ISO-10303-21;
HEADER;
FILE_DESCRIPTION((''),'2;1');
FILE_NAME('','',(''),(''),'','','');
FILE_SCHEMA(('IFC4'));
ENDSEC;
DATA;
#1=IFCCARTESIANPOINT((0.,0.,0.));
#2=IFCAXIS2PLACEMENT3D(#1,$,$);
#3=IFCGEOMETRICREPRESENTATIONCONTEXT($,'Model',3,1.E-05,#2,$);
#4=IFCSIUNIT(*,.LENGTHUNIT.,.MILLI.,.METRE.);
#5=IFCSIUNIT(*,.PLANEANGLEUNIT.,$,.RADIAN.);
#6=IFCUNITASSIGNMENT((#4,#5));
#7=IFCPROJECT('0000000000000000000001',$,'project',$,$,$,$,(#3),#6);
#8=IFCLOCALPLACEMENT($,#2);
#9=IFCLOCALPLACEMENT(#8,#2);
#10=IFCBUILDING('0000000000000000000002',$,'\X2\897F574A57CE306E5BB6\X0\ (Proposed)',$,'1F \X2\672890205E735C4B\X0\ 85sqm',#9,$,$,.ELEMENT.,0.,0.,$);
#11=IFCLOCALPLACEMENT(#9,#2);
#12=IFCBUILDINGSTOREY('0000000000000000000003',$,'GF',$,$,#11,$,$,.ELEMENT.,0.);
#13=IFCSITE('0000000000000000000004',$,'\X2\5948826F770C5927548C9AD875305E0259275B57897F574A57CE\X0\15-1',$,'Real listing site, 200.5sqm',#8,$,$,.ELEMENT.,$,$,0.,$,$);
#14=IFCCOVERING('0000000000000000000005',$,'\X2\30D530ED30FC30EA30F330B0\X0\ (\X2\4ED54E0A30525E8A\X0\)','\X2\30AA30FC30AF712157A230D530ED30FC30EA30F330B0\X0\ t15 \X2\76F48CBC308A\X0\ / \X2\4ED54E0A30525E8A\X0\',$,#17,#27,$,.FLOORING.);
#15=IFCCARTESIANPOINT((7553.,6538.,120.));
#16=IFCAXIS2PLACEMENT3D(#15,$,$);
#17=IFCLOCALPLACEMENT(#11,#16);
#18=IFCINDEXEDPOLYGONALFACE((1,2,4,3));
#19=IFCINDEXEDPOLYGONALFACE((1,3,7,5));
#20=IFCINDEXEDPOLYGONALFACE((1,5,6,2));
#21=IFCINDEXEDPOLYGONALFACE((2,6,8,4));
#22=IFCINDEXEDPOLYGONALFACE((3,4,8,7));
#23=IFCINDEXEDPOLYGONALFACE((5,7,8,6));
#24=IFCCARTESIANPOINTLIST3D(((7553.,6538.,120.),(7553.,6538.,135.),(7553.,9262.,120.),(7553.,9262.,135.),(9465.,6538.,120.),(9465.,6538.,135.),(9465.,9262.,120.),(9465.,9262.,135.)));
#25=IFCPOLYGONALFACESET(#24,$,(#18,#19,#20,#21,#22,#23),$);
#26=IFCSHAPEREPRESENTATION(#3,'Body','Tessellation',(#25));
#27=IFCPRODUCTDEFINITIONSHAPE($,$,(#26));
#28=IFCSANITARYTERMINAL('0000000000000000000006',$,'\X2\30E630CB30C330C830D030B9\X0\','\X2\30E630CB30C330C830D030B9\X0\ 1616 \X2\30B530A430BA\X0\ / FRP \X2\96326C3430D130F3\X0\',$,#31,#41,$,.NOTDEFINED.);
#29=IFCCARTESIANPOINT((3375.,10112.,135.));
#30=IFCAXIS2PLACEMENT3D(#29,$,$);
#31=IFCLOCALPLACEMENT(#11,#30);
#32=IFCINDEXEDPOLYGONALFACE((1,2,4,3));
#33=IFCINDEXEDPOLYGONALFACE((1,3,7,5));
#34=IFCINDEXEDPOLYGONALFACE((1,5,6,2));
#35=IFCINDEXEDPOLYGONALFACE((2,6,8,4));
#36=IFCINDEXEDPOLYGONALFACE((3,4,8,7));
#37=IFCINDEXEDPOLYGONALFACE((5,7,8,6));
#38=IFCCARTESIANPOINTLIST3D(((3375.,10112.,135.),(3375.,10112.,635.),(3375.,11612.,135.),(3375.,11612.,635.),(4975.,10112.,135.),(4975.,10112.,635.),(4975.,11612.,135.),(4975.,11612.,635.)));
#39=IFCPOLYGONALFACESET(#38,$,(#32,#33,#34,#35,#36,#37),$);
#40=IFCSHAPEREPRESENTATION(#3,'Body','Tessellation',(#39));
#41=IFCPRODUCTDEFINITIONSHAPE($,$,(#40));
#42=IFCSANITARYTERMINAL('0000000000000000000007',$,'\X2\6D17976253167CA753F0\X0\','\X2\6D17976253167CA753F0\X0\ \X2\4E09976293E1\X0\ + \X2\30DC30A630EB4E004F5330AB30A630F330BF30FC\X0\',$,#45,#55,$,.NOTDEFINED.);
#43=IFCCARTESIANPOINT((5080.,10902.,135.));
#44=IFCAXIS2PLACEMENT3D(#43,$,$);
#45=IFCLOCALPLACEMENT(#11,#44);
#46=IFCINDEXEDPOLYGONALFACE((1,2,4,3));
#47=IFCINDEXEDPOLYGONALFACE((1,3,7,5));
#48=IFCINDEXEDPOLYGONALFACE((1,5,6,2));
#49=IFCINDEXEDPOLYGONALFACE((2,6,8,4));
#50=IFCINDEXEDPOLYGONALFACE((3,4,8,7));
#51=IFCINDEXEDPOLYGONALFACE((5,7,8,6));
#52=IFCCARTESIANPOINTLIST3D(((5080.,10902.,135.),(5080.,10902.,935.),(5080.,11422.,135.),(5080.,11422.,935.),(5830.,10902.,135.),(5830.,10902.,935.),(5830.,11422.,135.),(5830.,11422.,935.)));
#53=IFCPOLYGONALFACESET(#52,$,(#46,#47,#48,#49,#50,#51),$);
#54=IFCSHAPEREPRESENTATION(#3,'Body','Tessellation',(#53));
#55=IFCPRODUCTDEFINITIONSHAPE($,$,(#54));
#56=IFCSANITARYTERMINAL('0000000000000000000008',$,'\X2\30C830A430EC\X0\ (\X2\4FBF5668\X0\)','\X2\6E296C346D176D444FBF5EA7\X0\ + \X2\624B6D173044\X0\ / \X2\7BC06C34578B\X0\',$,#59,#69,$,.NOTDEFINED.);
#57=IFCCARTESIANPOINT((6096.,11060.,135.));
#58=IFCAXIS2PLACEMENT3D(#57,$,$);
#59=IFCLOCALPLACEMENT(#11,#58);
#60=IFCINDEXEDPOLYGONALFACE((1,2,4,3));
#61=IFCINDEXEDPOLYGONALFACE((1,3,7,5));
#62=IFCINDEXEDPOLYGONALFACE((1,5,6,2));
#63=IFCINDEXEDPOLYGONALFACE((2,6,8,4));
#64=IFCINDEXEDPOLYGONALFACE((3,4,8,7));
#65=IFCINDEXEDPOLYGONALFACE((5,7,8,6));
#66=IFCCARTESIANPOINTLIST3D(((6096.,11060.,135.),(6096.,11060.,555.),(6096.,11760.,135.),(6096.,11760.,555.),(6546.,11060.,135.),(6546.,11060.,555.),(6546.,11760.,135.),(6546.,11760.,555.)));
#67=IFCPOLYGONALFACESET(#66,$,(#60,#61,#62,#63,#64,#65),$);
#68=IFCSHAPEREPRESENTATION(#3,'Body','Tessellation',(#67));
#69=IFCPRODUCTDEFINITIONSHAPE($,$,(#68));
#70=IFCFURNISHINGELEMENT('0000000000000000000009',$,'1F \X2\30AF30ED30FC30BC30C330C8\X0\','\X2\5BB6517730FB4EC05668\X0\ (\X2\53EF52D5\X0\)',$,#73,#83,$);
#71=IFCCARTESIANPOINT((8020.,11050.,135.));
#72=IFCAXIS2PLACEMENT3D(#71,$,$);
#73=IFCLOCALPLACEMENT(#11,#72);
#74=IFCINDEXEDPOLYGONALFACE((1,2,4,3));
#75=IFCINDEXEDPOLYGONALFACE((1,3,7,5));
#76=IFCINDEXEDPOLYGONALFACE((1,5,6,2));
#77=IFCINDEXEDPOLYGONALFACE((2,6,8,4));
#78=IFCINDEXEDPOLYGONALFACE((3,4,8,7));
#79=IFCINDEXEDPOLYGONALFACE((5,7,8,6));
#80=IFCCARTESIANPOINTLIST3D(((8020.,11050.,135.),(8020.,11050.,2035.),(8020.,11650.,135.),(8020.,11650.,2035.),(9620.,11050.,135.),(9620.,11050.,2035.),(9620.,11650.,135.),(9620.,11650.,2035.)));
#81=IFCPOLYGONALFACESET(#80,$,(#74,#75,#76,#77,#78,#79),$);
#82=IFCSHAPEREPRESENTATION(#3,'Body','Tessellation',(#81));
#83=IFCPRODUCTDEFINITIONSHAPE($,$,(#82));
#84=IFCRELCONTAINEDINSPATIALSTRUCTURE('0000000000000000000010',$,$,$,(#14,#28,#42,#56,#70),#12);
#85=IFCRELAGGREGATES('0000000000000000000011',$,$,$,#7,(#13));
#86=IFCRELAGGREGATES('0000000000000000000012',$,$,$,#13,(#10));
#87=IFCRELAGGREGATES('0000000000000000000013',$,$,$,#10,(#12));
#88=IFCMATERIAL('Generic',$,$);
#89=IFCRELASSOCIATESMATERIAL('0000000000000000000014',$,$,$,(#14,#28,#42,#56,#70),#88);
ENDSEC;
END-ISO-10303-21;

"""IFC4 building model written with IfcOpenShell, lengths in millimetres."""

from ifc_helpers import new_model, si_unit, frame, frame_2d, origin, place, context, project, spatial, rectangle, extrude, material, element, save


model = new_model("IFC4")

# Units and contexts
model_context = context("Model", 3, precision=1e-05, world=origin())
ifc_project = project(units=[si_unit("LENGTHUNIT", "METRE", prefix="MILLI"), si_unit("PLANEANGLEUNIT", "RADIAN")], contexts=[model_context])

# Site, building, storey
site_placement = place(None, origin())
site = spatial("IfcSite", under=ifc_project, at=site_placement, Name="奈良県大和高田市大字西坊城15-1", ObjectType="Real listing site, 200.5sqm", CompositionType="ELEMENT", RefElevation=0.0)
building_placement = place(site_placement, origin())
building = spatial("IfcBuilding", under=site, at=building_placement, Name="西坊城の家 (Proposed)", ObjectType="1F 木造平屋 85sqm", CompositionType="ELEMENT", ElevationOfRefHeight=0.0, ElevationOfTerrain=0.0)
storey_placement = place(building_placement, origin())
storey = spatial("IfcBuildingStorey", under=building, at=storey_placement, Name="GF", CompositionType="ELEMENT", Elevation=0.0)

# Covering
ifc_material_1 = material(Name="Generic")
covering_1_placement = place(storey_placement, frame((7553.0, 6538.0, 120.0)))
element("IfcCovering", 1, at=covering_1_placement, inside=storey, material=ifc_material_1, Name="フローリング (仕上げ床)", Description="オーク無垢フローリング t15 直貼り / 仕上げ床", PredefinedType="FLOORING", context=model_context, shape_type="SweptSolid", body=[
    extrude(rectangle(XDim=1912.0, YDim=2724.0, at=frame_2d((956.0, 1362.0))), frame((7553.0, 6538.0, 120.0)), (0.0, 0.0, 1.0), 15.0),
])

# Sanitary terminals
sanitary_terminal_1_placement = place(storey_placement, frame((3375.0, 10112.0, 135.0)))
element("IfcSanitaryTerminal", 2, at=sanitary_terminal_1_placement, inside=storey, material=ifc_material_1, Name="ユニットバス", Description="ユニットバス 1616 サイズ / FRP 防水パン", PredefinedType="NOTDEFINED", context=model_context, shape_type="SweptSolid", body=[
    extrude(rectangle(XDim=1600.0, YDim=1500.0, at=frame_2d((800.0, 750.0))), frame((3375.0, 10112.0, 135.0)), (0.0, 0.0, 1.0), 500.0),
])
sanitary_terminal_2_placement = place(storey_placement, frame((5080.0, 10902.0, 135.0)))
element("IfcSanitaryTerminal", 3, at=sanitary_terminal_2_placement, inside=storey, material=ifc_material_1, Name="洗面化粧台", Description="洗面化粧台 三面鏡 + ボウル一体カウンター", PredefinedType="NOTDEFINED", context=model_context, shape_type="SweptSolid", body=[
    extrude(rectangle(XDim=750.0, YDim=520.0, at=frame_2d((375.0, 260.0))), frame((5080.0, 10902.0, 135.0)), (0.0, 0.0, 1.0), 800.0),
])
sanitary_terminal_3_placement = place(storey_placement, frame((6096.0, 11060.0, 135.0)))
element("IfcSanitaryTerminal", 4, at=sanitary_terminal_3_placement, inside=storey, material=ifc_material_1, Name="トイレ (便器)", Description="温水洗浄便座 + 手洗い / 節水型", PredefinedType="NOTDEFINED", context=model_context, shape_type="SweptSolid", body=[
    extrude(rectangle(XDim=450.0, YDim=700.0, at=frame_2d((225.0, 350.0))), frame((6096.0, 11060.0, 135.0)), (0.0, 0.0, 1.0), 420.0),
])

# Furnishing element
furnishing_placement = place(storey_placement, frame((8020.0, 11050.0, 135.0)))
element("IfcFurnishingElement", 5, at=furnishing_placement, inside=storey, material=ifc_material_1, Name="1F クローゼット", Description="家具・什器 (可動)", context=model_context, shape_type="SweptSolid", body=[
    extrude(rectangle(XDim=1600.0, YDim=600.0, at=frame_2d((800.0, 300.0))), frame((8020.0, 11050.0, 135.0)), (0.0, 0.0, 1.0), 1900.0),
])

save(model, "model.ifc")
